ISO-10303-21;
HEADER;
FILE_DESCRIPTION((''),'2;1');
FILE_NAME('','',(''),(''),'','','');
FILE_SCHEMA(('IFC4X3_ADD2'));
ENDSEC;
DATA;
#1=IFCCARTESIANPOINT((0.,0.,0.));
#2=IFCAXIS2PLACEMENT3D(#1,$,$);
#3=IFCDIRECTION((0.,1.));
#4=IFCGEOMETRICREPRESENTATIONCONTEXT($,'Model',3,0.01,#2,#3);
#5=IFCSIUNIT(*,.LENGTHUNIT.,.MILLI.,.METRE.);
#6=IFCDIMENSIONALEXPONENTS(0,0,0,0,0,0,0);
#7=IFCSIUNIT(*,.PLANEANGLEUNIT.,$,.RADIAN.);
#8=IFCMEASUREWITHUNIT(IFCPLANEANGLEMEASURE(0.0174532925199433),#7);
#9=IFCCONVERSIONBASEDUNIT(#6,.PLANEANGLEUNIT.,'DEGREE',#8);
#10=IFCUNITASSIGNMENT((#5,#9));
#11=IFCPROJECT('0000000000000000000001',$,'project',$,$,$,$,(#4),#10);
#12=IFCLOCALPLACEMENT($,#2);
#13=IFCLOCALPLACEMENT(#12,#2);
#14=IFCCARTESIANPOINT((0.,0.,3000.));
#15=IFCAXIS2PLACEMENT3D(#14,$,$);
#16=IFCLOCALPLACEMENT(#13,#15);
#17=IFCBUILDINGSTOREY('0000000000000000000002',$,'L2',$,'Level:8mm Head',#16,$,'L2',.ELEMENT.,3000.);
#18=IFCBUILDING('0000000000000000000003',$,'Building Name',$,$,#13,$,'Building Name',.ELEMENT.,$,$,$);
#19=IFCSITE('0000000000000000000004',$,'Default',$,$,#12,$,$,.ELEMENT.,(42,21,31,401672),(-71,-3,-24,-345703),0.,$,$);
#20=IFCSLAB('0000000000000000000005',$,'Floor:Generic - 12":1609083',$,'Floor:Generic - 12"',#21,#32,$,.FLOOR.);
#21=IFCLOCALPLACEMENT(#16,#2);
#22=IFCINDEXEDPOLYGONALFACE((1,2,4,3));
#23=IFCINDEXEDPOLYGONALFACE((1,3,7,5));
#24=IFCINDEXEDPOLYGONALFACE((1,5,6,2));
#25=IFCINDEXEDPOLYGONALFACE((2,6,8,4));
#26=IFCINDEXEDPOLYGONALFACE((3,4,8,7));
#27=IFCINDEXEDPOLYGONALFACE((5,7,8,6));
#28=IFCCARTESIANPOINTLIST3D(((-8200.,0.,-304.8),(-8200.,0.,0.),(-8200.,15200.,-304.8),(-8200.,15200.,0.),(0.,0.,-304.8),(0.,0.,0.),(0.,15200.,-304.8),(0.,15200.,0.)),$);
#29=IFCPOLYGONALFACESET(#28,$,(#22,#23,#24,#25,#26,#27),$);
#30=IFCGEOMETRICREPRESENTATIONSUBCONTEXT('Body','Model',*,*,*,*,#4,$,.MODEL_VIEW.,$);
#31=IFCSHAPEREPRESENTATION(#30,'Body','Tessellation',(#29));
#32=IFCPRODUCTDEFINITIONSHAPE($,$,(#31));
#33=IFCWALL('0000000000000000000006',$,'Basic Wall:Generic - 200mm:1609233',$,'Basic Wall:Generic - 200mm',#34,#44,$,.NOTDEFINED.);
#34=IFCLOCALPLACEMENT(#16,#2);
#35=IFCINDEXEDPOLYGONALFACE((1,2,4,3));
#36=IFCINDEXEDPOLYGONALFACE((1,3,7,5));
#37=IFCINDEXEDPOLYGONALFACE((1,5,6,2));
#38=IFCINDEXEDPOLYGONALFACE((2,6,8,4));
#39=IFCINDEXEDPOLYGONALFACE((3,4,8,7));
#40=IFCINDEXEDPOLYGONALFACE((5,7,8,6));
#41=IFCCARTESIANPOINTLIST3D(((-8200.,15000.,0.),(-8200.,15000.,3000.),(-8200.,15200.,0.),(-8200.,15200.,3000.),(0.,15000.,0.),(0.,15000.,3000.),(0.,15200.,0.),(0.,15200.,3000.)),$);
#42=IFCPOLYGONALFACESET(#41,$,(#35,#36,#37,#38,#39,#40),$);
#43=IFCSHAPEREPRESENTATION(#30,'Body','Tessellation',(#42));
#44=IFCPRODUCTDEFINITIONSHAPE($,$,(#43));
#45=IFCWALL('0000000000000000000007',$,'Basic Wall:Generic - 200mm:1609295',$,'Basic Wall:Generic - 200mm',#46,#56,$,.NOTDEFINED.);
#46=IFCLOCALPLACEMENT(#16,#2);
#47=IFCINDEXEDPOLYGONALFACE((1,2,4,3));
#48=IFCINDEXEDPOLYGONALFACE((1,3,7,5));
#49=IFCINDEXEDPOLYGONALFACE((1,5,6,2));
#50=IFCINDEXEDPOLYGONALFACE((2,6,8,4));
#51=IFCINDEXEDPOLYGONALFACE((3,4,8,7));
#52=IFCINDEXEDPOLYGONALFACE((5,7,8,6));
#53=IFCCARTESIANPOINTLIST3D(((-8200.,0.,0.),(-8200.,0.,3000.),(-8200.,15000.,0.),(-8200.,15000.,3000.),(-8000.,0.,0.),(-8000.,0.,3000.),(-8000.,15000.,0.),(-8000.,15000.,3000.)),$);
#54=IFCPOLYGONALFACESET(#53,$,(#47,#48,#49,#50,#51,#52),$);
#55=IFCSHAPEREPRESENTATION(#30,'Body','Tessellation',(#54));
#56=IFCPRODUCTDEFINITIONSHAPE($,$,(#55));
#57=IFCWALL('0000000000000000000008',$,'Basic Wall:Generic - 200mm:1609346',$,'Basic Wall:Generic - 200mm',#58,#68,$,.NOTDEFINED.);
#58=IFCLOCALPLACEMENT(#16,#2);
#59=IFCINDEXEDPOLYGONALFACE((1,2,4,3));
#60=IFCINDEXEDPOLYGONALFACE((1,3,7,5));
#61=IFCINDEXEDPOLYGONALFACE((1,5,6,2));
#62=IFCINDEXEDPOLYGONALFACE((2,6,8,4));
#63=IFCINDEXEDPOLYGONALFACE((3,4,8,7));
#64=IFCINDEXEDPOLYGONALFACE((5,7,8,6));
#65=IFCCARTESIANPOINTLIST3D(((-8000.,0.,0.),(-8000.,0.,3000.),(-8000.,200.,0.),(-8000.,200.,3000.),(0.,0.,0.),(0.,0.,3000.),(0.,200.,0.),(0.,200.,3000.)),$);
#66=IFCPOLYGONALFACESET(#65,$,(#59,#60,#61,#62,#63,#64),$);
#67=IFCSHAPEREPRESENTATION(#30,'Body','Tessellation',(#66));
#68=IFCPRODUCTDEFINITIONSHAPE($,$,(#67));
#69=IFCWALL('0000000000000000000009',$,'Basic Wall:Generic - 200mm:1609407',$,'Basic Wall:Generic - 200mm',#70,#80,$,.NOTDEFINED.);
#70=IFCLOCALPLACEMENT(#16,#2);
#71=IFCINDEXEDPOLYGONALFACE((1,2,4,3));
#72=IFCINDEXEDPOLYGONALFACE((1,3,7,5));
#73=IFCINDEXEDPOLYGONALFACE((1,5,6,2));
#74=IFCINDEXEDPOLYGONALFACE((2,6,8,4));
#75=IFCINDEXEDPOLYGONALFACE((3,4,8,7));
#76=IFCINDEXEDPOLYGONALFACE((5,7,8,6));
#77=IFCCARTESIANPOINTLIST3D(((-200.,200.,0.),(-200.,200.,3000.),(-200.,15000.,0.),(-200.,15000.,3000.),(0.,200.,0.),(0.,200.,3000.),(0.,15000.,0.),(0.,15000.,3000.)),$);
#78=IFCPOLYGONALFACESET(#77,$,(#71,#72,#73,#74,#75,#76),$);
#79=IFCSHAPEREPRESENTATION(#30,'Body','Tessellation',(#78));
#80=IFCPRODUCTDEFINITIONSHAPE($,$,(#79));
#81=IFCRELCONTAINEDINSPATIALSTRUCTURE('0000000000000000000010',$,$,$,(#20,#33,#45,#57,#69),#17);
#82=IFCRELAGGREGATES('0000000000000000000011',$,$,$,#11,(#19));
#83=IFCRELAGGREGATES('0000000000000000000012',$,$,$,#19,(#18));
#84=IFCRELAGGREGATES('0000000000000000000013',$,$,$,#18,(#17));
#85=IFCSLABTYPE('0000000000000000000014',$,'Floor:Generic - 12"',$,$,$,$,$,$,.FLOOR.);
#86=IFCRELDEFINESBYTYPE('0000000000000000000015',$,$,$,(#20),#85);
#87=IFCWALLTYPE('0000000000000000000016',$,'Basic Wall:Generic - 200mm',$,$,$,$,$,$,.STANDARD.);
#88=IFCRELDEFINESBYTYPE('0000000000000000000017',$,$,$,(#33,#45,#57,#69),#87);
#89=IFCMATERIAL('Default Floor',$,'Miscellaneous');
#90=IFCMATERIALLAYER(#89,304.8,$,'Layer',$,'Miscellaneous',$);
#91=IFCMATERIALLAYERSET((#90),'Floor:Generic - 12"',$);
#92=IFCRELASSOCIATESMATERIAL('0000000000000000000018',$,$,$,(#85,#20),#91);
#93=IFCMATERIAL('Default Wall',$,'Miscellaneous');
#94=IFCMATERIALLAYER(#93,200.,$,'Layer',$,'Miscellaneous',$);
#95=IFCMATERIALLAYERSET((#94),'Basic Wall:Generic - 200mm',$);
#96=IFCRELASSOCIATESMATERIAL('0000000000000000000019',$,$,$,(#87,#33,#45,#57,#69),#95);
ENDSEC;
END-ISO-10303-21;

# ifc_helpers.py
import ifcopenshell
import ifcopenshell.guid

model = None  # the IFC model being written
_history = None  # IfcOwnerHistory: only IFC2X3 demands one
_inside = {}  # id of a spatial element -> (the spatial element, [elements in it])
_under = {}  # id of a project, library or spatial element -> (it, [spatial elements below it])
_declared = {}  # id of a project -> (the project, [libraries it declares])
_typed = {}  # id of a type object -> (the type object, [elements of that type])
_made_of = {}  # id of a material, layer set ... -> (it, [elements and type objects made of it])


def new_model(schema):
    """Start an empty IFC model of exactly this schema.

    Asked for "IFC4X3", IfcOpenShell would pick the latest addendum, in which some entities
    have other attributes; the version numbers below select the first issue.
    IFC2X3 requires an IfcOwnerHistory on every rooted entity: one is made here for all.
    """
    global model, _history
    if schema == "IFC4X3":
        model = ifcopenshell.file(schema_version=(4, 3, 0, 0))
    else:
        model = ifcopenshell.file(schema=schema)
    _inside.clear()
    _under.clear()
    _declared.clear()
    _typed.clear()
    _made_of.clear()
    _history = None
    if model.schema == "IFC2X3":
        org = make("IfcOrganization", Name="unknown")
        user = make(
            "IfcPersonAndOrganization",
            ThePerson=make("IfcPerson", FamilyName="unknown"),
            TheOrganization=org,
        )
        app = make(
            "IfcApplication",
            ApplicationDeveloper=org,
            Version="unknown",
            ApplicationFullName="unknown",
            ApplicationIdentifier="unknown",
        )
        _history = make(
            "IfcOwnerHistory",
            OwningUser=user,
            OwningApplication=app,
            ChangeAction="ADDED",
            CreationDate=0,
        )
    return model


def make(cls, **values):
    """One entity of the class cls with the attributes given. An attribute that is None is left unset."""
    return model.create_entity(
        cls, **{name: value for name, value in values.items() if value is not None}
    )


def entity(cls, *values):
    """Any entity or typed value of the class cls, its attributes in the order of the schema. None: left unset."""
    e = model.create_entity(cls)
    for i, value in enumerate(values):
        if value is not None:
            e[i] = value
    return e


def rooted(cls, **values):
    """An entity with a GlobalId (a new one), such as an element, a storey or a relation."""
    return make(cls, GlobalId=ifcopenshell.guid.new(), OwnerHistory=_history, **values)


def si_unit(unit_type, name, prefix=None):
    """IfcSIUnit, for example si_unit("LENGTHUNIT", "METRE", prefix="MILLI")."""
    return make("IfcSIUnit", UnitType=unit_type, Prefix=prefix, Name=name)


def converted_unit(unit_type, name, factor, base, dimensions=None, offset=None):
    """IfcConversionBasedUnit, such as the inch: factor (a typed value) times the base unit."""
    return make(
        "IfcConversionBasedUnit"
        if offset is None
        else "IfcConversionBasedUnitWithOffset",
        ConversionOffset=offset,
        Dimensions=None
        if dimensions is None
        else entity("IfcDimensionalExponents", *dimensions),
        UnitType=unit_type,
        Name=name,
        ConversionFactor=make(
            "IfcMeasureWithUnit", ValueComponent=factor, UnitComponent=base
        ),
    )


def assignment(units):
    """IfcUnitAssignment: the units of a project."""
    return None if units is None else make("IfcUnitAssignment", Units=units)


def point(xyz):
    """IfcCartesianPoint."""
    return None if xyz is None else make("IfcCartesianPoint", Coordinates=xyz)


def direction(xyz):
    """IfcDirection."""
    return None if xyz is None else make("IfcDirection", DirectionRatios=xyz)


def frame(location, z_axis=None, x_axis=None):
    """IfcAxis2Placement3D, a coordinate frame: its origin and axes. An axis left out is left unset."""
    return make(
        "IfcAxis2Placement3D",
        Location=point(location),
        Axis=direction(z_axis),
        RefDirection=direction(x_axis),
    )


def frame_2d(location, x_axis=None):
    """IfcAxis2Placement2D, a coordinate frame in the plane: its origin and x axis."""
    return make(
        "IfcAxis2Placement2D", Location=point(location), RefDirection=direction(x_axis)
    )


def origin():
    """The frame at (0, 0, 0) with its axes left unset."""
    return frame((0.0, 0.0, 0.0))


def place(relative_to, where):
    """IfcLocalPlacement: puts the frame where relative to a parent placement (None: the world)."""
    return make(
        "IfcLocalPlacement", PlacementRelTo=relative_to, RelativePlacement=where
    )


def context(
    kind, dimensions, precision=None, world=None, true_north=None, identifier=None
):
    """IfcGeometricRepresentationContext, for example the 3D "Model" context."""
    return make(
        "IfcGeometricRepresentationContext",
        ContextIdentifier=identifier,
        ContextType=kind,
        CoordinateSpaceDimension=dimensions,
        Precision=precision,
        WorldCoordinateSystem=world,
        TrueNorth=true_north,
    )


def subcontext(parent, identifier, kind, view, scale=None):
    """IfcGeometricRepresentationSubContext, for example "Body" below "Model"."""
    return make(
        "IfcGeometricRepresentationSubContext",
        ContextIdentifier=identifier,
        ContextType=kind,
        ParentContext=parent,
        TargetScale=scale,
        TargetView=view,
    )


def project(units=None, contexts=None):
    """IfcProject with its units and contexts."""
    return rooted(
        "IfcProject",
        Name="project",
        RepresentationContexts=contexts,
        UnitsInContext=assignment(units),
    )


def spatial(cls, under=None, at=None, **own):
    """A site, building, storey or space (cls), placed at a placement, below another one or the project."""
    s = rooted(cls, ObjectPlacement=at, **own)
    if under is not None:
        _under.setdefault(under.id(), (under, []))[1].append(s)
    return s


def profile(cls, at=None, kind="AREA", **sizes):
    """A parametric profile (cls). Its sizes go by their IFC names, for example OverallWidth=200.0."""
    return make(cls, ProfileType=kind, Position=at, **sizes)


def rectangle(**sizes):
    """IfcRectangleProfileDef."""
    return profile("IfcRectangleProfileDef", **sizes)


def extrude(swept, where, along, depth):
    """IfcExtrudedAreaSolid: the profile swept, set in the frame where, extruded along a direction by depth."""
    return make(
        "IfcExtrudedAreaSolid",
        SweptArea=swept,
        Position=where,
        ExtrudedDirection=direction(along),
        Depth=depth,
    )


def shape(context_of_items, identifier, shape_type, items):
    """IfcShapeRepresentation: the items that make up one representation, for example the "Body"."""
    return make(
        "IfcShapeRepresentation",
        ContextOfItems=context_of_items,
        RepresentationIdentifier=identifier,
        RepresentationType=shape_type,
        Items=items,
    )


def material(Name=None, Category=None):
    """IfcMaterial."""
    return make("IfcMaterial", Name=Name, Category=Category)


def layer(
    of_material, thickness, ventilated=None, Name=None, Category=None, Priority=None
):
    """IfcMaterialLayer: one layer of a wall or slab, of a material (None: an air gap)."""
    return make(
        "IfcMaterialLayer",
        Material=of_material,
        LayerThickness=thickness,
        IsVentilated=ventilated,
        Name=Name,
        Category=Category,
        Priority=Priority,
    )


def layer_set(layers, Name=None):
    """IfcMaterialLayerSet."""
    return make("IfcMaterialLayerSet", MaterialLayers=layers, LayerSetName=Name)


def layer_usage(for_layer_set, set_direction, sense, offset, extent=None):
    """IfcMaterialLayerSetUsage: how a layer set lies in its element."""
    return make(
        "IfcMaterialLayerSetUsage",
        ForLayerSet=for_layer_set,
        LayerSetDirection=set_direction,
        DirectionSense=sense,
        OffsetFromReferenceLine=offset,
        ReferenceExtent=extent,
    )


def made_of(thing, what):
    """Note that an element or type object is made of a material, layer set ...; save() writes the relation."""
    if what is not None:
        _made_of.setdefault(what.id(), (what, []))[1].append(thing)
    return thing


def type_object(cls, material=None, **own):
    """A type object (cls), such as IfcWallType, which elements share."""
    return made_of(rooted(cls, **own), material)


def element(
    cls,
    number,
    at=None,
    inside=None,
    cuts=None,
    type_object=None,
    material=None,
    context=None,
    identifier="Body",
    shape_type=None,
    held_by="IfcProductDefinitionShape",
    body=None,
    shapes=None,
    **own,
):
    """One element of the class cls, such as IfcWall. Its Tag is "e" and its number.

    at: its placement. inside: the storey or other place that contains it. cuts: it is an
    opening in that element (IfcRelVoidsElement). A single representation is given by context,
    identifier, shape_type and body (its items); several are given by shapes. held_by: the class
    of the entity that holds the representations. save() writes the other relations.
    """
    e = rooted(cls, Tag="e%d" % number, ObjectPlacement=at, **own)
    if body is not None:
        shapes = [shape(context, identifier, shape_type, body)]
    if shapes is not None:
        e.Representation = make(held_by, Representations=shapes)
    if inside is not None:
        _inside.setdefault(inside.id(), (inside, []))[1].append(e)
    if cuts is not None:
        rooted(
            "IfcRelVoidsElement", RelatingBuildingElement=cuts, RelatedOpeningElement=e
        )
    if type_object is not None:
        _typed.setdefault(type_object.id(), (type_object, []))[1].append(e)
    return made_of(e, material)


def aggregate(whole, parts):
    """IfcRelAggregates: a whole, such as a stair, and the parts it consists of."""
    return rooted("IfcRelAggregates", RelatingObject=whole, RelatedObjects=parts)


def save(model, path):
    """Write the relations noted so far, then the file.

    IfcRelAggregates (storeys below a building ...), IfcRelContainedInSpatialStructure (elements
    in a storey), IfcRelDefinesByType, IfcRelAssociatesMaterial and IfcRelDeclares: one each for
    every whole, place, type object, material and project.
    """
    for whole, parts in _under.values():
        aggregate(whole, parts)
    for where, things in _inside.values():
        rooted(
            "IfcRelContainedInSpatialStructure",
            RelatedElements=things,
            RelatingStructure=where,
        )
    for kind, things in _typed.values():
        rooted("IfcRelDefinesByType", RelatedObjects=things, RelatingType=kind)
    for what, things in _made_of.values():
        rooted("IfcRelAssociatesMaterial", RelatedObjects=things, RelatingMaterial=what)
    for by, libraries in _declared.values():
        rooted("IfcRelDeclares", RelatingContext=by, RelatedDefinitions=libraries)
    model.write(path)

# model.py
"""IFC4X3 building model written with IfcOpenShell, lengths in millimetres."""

from ifc_helpers import new_model, entity, si_unit, converted_unit, direction, frame, frame_2d, origin, place, context, subcontext, project, spatial, rectangle, extrude, material, layer, layer_set, layer_usage, type_object, element, save


model = new_model("IFC4X3")

# Units and contexts
model_context = context("Model", 3, precision=0.01, world=origin(), true_north=direction((0.0, 1.0)))
body_context = subcontext(model_context, "Body", "Model", "MODEL_VIEW")
ifc_project = project(units=[si_unit("LENGTHUNIT", "METRE", prefix="MILLI"), converted_unit("PLANEANGLEUNIT", "DEGREE", entity("IfcPlaneAngleMeasure", 0.0174532925199433), si_unit("PLANEANGLEUNIT", "RADIAN"), dimensions=[0, 0, 0, 0, 0, 0, 0])], contexts=[model_context])

# Site, building, storey
site_placement = place(None, origin())
site = spatial("IfcSite", under=ifc_project, at=site_placement, Name="Default", CompositionType="ELEMENT", RefLatitude=(42, 21, 31, 401672), RefLongitude=(-71, -3, -24, -345703), RefElevation=0.0)
building_placement = place(site_placement, origin())
building = spatial("IfcBuilding", under=site, at=building_placement, Name="Building Name", LongName="Building Name", CompositionType="ELEMENT")
storey_placement = place(building_placement, frame((0.0, 0.0, 3000.0)))
storey = spatial("IfcBuildingStorey", under=building, at=storey_placement, Name="L2", ObjectType="Level:8mm Head", LongName="L2", CompositionType="ELEMENT", Elevation=3000.0)

# Slab
ifc_material_1 = material(Name="Default Floor", Category="Miscellaneous")
ifc_layer_1 = layer(ifc_material_1, 304.8, Name="Layer", Category="Miscellaneous")
ifc_layer_set_1 = layer_set([ifc_layer_1], Name="Floor:Generic - 12\"")
ifc_layer_usage = layer_usage(ifc_layer_set_1, "AXIS3", "POSITIVE", 0.0)
slab_type = type_object("IfcSlabType", Name="Floor:Generic - 12\"", PredefinedType="FLOOR", material=ifc_layer_set_1)
slab_placement = place(storey_placement, origin())
element("IfcSlab", 1, at=slab_placement, inside=storey, type_object=slab_type, material=ifc_layer_usage, Name="Floor:Generic - 12\":1609083", ObjectType="Floor:Generic - 12\"", PredefinedType="FLOOR", context=body_context, shape_type="SweptSolid", body=[
    extrude(rectangle(XDim=15200.0, YDim=8200.0, at=frame_2d((0.0, 0.0), x_axis=(1.0, 0.0))), frame((-4100.0, 7600.0, 0.0), z_axis=(0.0, 0.0, -1.0), x_axis=(0.0, 1.0, 0.0)), (0.0, 0.0, 1.0), 304.8),
])

# Walls
ifc_material_2 = material(Name="Default Wall", Category="Miscellaneous")
ifc_layer_2 = layer(ifc_material_2, 200.0, Name="Layer", Category="Miscellaneous")
ifc_layer_set_2 = layer_set([ifc_layer_2], Name="Basic Wall:Generic - 200mm")
wall_type = type_object("IfcWallType", Name="Basic Wall:Generic - 200mm", PredefinedType="STANDARD", material=ifc_layer_set_2)
wall_1_placement = place(storey_placement, frame((0.0, 15100.0, 0.0), z_axis=(0.0, 0.0, 1.0), x_axis=(-1.0, 0.0, 0.0)))
element("IfcWall", 2, at=wall_1_placement, inside=storey, type_object=wall_type, material=ifc_layer_set_2, Name="Basic Wall:Generic - 200mm:1609233", ObjectType="Basic Wall:Generic - 200mm", PredefinedType="NOTDEFINED", context=body_context, shape_type="SweptSolid", body=[
    extrude(rectangle(XDim=8200.0, YDim=200.0, at=frame_2d((4100.0, 0.0), x_axis=(-1.0, 0.0))), origin(), (0.0, 0.0, 1.0), 3000.0),
])
wall_2_placement = place(storey_placement, frame((-8100.0, 15000.0, 0.0), z_axis=(0.0, 0.0, 1.0), x_axis=(0.0, -1.0, 0.0)))
element("IfcWall", 3, at=wall_2_placement, inside=storey, type_object=wall_type, material=ifc_layer_set_2, Name="Basic Wall:Generic - 200mm:1609295", ObjectType="Basic Wall:Generic - 200mm", PredefinedType="NOTDEFINED", context=body_context, shape_type="SweptSolid", body=[
    extrude(rectangle(XDim=15000.0, YDim=200.0, at=frame_2d((7500.0, 0.0), x_axis=(-1.0, 0.0))), origin(), (0.0, 0.0, 1.0), 3000.0),
])
wall_3_placement = place(storey_placement, frame((-8000.0, 100.0, 0.0)))
element("IfcWall", 4, at=wall_3_placement, inside=storey, type_object=wall_type, material=ifc_layer_set_2, Name="Basic Wall:Generic - 200mm:1609346", ObjectType="Basic Wall:Generic - 200mm", PredefinedType="NOTDEFINED", context=body_context, shape_type="SweptSolid", body=[
    extrude(rectangle(XDim=8000.0, YDim=200.0, at=frame_2d((4000.0, 0.0), x_axis=(-1.0, 0.0))), origin(), (0.0, 0.0, 1.0), 3000.0),
])
wall_4_placement = place(storey_placement, frame((-100.0, 200.0, 0.0), z_axis=(0.0, 0.0, 1.0), x_axis=(0.0, 1.0, 0.0)))
element("IfcWall", 5, at=wall_4_placement, inside=storey, type_object=wall_type, material=ifc_layer_set_2, Name="Basic Wall:Generic - 200mm:1609407", ObjectType="Basic Wall:Generic - 200mm", PredefinedType="NOTDEFINED", context=body_context, shape_type="SweptSolid", body=[
    extrude(rectangle(XDim=14800.0, YDim=200.0, at=frame_2d((7400.0, 0.0), x_axis=(-1.0, 0.0))), origin(), (0.0, 0.0, 1.0), 3000.0),
])

save(model, "model.ifc")
